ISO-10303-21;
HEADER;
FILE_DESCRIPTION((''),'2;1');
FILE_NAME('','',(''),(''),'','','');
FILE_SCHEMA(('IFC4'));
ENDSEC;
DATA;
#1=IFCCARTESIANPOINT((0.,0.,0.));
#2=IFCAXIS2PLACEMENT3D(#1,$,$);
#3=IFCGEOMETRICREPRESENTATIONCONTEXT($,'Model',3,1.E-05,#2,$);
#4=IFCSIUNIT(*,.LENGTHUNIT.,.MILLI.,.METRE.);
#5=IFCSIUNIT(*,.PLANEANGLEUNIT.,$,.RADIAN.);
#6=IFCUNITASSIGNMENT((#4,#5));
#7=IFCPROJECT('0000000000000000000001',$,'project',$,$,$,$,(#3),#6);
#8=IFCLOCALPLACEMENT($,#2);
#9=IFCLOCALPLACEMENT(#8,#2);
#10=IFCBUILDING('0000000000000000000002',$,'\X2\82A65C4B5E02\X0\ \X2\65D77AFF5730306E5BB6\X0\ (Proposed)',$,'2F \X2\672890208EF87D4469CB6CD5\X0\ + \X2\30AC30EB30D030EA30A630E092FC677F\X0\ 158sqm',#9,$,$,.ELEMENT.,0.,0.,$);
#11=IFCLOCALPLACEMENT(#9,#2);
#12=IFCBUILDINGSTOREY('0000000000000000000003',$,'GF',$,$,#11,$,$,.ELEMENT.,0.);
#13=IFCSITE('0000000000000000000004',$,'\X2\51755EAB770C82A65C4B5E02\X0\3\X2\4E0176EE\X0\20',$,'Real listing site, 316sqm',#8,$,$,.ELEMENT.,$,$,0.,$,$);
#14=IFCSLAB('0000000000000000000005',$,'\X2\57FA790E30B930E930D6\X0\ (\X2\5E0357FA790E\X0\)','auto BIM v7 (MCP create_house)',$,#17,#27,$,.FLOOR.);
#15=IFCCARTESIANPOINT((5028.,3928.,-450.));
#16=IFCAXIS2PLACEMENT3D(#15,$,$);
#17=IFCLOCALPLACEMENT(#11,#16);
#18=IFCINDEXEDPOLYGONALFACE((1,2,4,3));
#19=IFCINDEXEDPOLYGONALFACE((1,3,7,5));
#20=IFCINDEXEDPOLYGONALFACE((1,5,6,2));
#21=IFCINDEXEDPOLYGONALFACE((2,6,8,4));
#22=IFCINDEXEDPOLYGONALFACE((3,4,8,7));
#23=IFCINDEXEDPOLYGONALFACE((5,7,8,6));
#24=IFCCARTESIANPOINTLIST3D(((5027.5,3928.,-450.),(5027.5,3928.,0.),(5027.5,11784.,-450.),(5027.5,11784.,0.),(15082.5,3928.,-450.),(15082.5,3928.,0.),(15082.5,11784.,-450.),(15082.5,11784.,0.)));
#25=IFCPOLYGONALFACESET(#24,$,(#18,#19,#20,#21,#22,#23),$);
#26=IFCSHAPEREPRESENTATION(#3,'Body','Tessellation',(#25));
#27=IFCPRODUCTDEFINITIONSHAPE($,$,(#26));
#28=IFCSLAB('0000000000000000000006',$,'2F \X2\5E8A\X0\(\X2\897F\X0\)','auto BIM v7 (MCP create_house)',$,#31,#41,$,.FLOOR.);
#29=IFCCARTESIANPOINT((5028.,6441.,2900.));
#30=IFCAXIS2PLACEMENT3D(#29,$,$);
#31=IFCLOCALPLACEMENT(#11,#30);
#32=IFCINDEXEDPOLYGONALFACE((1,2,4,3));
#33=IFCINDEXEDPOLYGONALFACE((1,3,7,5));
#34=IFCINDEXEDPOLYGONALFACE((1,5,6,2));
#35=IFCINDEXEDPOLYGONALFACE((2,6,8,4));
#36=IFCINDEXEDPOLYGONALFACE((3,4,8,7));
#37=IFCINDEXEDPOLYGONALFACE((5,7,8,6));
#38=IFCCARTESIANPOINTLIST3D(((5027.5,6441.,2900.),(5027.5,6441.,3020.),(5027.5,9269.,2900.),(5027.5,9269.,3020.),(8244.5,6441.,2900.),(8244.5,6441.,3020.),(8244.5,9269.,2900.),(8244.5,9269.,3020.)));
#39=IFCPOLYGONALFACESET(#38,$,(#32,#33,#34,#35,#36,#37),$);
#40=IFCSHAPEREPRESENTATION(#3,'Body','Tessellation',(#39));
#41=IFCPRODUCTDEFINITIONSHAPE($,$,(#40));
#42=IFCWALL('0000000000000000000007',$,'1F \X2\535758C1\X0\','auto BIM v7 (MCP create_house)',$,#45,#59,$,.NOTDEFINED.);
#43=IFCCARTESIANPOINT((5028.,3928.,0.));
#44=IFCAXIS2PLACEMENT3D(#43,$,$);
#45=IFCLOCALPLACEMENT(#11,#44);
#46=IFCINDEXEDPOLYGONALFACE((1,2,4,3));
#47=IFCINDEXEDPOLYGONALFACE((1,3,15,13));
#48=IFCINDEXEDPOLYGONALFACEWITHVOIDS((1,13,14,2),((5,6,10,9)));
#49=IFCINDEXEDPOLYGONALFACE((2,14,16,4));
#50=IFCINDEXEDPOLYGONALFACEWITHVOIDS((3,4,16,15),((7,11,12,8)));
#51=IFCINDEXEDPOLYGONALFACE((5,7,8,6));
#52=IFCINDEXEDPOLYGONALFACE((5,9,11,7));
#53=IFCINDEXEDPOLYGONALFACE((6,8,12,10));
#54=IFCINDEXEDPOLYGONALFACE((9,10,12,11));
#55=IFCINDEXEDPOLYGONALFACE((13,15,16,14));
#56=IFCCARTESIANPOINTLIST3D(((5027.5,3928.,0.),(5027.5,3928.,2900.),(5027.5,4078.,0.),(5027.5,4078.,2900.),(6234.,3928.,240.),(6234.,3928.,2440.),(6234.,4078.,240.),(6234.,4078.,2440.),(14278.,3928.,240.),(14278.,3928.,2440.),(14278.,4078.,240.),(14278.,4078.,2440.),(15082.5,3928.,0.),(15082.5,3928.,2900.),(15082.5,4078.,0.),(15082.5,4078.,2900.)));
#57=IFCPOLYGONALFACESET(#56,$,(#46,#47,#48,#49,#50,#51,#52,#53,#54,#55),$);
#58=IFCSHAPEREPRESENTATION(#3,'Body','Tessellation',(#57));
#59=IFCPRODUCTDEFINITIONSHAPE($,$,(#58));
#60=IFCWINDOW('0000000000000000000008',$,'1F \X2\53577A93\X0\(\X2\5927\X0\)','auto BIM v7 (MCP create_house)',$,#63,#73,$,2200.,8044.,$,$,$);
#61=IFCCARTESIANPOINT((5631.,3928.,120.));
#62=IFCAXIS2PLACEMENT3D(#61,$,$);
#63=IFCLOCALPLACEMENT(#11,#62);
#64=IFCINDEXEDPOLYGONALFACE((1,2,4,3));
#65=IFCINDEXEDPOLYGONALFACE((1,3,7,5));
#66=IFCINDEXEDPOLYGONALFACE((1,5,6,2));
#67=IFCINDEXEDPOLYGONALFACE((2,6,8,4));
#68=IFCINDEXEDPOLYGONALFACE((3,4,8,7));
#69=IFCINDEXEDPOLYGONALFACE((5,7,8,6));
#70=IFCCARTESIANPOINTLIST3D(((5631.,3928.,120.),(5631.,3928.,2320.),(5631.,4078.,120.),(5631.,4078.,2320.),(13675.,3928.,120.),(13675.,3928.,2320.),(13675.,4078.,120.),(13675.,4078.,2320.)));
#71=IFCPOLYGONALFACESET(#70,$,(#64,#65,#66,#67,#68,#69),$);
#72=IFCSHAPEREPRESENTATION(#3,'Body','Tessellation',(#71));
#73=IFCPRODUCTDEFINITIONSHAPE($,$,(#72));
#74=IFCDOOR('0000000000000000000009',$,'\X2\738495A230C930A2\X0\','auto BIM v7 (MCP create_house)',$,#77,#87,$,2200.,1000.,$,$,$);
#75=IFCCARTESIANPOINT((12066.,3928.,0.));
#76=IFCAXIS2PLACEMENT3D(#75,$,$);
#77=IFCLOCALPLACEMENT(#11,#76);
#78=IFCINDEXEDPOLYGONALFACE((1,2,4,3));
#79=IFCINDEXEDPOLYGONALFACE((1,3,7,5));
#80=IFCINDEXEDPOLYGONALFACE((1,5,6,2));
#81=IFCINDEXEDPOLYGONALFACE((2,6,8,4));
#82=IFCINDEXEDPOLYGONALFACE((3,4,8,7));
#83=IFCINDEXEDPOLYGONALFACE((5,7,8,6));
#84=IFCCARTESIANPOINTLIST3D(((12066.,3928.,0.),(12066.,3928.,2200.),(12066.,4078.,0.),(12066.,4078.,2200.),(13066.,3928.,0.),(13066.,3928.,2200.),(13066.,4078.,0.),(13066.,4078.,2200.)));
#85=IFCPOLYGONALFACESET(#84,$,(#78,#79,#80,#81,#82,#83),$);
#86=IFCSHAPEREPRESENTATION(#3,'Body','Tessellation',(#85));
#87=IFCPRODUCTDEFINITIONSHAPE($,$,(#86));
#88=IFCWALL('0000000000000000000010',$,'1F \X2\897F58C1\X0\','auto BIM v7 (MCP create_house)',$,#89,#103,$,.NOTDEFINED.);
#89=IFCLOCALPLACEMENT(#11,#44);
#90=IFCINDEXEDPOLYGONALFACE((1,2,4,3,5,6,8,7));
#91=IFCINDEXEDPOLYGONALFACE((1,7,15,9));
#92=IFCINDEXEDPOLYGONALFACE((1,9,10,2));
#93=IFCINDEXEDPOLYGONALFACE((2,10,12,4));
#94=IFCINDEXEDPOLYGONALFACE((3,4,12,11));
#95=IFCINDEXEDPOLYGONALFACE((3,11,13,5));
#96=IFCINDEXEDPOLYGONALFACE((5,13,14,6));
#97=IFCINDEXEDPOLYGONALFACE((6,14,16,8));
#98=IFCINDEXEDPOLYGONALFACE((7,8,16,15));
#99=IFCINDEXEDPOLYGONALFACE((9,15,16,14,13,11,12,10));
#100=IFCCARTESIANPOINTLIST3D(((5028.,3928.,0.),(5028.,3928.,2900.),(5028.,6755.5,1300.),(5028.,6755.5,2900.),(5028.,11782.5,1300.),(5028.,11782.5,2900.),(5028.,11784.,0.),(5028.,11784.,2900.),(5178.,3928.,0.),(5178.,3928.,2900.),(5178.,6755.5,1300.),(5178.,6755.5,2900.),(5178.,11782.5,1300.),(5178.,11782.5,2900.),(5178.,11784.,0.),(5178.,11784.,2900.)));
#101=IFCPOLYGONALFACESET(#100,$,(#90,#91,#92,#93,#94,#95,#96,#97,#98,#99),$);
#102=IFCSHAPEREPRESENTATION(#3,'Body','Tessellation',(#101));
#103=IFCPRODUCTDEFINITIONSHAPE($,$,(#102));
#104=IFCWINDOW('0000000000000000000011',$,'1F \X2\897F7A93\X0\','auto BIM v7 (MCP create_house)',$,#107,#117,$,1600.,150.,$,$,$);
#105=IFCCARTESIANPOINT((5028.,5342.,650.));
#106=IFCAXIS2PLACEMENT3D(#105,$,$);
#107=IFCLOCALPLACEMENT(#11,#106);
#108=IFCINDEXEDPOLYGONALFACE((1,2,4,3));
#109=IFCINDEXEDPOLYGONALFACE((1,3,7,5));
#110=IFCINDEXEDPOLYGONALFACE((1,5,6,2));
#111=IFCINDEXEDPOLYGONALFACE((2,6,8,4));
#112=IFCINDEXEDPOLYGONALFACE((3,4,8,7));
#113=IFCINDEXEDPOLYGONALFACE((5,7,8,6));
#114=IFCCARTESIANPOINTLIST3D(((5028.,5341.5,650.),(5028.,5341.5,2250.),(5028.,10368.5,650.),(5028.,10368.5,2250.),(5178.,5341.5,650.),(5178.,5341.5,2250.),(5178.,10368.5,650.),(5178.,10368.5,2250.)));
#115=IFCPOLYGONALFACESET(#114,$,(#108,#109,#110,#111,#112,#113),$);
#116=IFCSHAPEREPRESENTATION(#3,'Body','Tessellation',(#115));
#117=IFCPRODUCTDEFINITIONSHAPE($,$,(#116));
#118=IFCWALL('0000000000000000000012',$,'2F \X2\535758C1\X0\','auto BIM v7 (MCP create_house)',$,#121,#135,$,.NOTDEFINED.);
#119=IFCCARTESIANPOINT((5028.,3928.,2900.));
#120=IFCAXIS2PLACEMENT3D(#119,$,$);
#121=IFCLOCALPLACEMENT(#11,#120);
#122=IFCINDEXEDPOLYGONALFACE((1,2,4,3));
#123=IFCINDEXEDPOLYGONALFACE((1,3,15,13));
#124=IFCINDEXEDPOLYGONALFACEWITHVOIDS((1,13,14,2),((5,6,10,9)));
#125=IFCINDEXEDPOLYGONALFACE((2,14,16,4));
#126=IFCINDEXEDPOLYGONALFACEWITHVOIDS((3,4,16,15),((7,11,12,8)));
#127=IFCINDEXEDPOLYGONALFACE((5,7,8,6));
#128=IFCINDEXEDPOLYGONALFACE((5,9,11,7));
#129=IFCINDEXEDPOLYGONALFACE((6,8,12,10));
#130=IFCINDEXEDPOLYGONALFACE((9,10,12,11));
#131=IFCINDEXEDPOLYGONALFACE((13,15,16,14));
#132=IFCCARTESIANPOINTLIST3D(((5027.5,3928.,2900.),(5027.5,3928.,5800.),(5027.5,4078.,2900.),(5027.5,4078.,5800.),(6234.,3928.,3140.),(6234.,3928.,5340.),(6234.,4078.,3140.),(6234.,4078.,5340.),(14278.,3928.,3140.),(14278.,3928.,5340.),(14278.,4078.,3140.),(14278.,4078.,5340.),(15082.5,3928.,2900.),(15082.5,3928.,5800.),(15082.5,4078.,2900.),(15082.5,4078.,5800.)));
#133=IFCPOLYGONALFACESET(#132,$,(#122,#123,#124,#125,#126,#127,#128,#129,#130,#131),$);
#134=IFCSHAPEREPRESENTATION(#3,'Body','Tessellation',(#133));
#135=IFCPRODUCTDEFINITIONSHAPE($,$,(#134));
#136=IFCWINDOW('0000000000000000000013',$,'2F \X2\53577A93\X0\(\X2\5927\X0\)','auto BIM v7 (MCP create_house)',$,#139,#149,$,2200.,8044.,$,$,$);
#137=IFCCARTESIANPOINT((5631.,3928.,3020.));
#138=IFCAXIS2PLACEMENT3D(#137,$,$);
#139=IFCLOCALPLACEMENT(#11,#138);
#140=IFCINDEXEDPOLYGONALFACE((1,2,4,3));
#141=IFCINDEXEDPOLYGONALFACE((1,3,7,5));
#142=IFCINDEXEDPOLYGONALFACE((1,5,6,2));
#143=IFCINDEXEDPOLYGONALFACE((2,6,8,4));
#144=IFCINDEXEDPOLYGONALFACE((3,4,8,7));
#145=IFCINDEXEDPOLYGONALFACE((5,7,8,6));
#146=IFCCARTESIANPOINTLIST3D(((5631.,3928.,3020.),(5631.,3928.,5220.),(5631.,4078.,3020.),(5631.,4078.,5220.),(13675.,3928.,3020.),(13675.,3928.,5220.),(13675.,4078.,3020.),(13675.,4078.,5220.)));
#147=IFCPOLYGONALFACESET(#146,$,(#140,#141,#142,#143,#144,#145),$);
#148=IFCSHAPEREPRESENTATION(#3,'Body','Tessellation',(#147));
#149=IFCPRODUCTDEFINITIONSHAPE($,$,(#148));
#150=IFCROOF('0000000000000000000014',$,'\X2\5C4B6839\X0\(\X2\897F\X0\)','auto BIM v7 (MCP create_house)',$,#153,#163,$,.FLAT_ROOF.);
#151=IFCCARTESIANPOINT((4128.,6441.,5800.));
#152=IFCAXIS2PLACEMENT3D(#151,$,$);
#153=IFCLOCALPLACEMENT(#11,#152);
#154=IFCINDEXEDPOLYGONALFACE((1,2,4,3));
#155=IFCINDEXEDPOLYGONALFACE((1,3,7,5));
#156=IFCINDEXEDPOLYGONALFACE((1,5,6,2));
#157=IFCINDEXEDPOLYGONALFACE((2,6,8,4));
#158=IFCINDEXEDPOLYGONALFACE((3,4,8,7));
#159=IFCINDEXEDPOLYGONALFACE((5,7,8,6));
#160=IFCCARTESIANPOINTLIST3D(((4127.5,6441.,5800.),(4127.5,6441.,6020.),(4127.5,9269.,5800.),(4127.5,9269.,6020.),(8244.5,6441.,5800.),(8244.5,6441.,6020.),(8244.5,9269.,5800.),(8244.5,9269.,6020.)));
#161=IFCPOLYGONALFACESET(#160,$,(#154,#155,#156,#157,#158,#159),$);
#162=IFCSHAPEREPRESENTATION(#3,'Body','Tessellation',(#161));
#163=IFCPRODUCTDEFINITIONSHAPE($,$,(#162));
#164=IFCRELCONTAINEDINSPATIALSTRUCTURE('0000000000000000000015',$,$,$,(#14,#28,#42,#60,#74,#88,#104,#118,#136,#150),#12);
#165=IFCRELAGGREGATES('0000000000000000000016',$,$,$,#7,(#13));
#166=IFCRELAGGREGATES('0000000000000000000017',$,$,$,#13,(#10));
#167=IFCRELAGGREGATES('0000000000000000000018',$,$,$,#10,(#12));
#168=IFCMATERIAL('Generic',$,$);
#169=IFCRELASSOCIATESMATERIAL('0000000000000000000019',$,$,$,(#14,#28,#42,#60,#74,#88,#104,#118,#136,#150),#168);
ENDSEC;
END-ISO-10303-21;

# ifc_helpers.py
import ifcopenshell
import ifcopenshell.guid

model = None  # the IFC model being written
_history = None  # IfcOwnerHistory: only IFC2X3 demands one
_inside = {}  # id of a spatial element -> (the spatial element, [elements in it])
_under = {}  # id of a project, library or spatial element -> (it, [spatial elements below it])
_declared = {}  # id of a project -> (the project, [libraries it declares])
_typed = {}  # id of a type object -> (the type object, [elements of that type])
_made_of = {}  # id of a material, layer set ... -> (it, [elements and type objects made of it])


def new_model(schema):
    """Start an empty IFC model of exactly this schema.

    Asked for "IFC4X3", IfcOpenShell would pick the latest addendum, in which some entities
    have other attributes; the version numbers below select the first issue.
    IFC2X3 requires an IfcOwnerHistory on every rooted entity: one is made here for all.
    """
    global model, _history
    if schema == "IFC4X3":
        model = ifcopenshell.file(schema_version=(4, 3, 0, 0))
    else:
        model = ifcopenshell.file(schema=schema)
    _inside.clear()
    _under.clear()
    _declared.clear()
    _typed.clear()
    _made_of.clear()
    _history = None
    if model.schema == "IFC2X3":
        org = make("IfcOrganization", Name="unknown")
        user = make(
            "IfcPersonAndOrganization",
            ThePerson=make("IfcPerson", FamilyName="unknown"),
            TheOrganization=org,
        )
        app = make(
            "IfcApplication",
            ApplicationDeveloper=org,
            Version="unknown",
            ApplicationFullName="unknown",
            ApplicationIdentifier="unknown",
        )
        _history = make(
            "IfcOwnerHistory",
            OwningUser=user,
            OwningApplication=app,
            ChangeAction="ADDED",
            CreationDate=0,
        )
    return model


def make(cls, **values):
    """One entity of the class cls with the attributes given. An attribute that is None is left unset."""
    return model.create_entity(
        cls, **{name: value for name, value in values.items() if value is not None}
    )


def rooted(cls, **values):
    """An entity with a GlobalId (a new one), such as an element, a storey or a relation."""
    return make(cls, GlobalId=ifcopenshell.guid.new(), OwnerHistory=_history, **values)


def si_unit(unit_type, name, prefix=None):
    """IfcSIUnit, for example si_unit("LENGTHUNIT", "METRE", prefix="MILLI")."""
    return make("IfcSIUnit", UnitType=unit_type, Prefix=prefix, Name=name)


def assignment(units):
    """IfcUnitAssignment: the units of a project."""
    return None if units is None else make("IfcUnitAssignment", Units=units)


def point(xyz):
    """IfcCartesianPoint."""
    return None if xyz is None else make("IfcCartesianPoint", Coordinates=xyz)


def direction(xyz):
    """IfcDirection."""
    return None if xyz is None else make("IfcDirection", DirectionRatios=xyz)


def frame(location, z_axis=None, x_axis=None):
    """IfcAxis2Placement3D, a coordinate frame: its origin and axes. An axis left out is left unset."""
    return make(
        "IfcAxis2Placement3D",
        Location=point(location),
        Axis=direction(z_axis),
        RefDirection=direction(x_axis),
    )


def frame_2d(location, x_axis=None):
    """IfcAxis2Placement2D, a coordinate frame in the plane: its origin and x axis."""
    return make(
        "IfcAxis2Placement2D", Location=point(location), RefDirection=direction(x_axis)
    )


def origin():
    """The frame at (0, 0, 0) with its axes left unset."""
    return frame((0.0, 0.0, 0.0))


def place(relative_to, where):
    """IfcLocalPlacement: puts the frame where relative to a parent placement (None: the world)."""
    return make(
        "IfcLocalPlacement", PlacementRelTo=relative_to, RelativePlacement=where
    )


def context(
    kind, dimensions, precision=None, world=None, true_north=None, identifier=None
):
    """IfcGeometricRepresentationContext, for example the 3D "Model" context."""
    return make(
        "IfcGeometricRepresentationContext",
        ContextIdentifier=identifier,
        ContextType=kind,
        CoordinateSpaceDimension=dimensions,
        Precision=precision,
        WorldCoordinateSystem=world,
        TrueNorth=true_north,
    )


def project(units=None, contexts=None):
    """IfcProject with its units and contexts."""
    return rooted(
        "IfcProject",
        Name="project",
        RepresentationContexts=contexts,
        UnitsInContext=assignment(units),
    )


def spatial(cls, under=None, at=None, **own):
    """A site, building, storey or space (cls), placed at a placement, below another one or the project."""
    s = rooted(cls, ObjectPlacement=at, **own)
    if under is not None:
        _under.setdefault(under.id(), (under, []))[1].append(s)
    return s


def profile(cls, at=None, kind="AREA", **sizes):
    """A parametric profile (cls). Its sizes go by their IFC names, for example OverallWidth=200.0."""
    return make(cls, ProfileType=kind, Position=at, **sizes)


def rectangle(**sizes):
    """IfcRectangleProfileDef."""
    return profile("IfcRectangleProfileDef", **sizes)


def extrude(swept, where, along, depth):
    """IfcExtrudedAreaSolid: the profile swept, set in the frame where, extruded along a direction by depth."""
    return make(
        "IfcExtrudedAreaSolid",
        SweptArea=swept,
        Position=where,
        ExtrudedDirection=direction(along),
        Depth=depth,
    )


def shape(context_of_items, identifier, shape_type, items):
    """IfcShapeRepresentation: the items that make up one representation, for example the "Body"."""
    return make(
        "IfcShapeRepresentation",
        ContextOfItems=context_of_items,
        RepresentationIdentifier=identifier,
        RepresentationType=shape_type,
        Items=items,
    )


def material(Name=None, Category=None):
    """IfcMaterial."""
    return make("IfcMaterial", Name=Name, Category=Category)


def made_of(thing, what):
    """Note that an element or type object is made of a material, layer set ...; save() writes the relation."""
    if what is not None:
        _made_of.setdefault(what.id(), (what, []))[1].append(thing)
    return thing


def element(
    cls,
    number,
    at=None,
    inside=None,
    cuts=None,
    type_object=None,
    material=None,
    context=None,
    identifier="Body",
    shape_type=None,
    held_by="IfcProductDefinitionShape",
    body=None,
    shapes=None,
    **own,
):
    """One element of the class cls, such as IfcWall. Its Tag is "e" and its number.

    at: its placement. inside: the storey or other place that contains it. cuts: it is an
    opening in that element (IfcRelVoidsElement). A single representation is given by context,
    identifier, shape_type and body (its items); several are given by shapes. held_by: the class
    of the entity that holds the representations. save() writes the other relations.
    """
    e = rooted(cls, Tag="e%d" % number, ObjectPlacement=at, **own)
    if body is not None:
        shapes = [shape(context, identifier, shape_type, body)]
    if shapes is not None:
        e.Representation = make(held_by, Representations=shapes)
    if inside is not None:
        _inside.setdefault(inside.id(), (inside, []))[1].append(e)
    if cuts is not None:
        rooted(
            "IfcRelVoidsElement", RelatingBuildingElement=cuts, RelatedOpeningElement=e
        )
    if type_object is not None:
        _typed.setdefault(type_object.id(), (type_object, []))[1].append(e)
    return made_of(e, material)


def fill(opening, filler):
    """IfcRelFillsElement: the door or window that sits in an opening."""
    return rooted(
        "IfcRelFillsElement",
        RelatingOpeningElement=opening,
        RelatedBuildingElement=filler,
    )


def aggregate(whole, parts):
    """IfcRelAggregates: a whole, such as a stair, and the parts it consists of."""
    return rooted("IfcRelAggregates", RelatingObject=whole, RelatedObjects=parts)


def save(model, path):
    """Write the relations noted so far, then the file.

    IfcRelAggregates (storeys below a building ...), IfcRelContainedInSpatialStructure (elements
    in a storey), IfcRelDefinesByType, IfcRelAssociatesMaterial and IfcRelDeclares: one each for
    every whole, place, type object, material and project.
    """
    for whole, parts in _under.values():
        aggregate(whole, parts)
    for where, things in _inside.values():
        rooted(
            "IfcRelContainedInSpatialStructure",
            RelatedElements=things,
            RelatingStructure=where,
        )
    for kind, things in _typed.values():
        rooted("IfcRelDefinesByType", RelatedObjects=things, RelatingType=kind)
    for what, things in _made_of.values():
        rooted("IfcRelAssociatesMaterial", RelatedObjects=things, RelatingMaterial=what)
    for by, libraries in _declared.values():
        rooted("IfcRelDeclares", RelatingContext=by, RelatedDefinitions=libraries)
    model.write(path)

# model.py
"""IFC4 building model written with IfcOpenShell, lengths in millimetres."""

from ifc_helpers import new_model, si_unit, frame, frame_2d, origin, place, context, project, spatial, rectangle, extrude, material, element, fill, save


model = new_model("IFC4")

# Units and contexts
model_context = context("Model", 3, precision=1e-05, world=origin())
ifc_project = project(units=[si_unit("LENGTHUNIT", "METRE", prefix="MILLI"), si_unit("PLANEANGLEUNIT", "RADIAN")], contexts=[model_context])

# Site, building, storey
site_placement = place(None, origin())
site = spatial("IfcSite", under=ifc_project, at=site_placement, Name="兵庫県芦屋市3丁目20", ObjectType="Real listing site, 316sqm", CompositionType="ELEMENT", RefElevation=0.0)
building_placement = place(site_placement, origin())
building = spatial("IfcBuilding", under=site, at=building_placement, Name="芦屋市 旗竿地の家 (Proposed)", ObjectType="2F 木造軸組構法 + ガルバリウム鋼板 158sqm", CompositionType="ELEMENT", ElevationOfRefHeight=0.0, ElevationOfTerrain=0.0)
storey_placement = place(building_placement, origin())
storey = spatial("IfcBuildingStorey", under=building, at=storey_placement, Name="GF", CompositionType="ELEMENT", Elevation=0.0)

# Slabs
ifc_material = material(Name="Generic")
slab_1_placement = place(storey_placement, frame((5028.0, 3928.0, -450.0)))
element("IfcSlab", 1, at=slab_1_placement, inside=storey, material=ifc_material, Name="基礎スラブ (布基礎)", Description="auto BIM v7 (MCP create_house)", PredefinedType="FLOOR", context=model_context, shape_type="SweptSolid", body=[
    extrude(rectangle(XDim=10055.0, YDim=7856.0, at=frame_2d((5027.0, 3928.0))), frame((5028.0, 3928.0, -450.0)), (0.0, 0.0, 1.0), 450.0),
])
slab_2_placement = place(storey_placement, frame((5028.0, 6441.0, 2900.0)))
element("IfcSlab", 2, at=slab_2_placement, inside=storey, material=ifc_material, Name="2F 床(西)", Description="auto BIM v7 (MCP create_house)", PredefinedType="FLOOR", context=model_context, shape_type="SweptSolid", body=[
    extrude(rectangle(XDim=3217.0, YDim=2828.0, at=frame_2d((1608.0, 1414.0))), frame((5028.0, 6441.0, 2900.0)), (0.0, 0.0, 1.0), 120.0),
])

# Wall, openings, window, door
wall_1_placement = place(storey_placement, frame((5028.0, 3928.0, 0.0)))
wall_1 = element("IfcWall", 3, at=wall_1_placement, inside=storey, material=ifc_material, Name="1F 南壁", Description="auto BIM v7 (MCP create_house)", PredefinedType="NOTDEFINED", context=model_context, shape_type="SweptSolid", body=[
    extrude(rectangle(XDim=10055.0, YDim=150.0, at=frame_2d((5027.0, 75.0))), frame((5028.0, 3928.0, 0.0)), (0.0, 0.0, 1.0), 2900.0),
])
opening_1_placement = place(storey_placement, frame((5631.0, 3928.0, 120.0)))
opening_1 = element("IfcOpeningElement", 4, at=opening_1_placement, cuts=wall_1, PredefinedType="NOTDEFINED", context=model_context, shape_type="SweptSolid", body=[
    extrude(rectangle(XDim=8044.0, YDim=150.0, at=frame_2d((4022.0, 75.0))), frame((5631.0, 3928.0, 120.0)), (0.0, 0.0, 1.0), 2200.0),
])
opening_2_placement = place(storey_placement, frame((12066.0, 3928.0, 0.0)))
opening_2 = element("IfcOpeningElement", 5, at=opening_2_placement, cuts=wall_1, PredefinedType="NOTDEFINED", context=model_context, shape_type="SweptSolid", body=[
    extrude(rectangle(XDim=1000.0, YDim=150.0, at=frame_2d((500.0, 75.0))), frame((12066.0, 3928.0, 0.0)), (0.0, 0.0, 1.0), 2200.0),
])
window_1_placement = place(storey_placement, frame((5631.0, 3928.0, 120.0)))
window_1 = element("IfcWindow", 6, at=window_1_placement, inside=storey, material=ifc_material, Name="1F 南窓(大)", Description="auto BIM v7 (MCP create_house)", OverallHeight=2200.0, OverallWidth=8044.0, context=model_context, shape_type="SweptSolid", body=[
    extrude(rectangle(XDim=8044.0, YDim=150.0, at=frame_2d((4022.0, 75.0))), frame((5631.0, 3928.0, 120.0)), (0.0, 0.0, 1.0), 2200.0),
])
fill(opening_1, window_1)
door_placement = place(storey_placement, frame((12066.0, 3928.0, 0.0)))
door = element("IfcDoor", 7, at=door_placement, inside=storey, material=ifc_material, Name="玄関ドア", Description="auto BIM v7 (MCP create_house)", OverallHeight=2200.0, OverallWidth=1000.0, context=model_context, shape_type="SweptSolid", body=[
    extrude(rectangle(XDim=1000.0, YDim=150.0, at=frame_2d((500.0, 75.0))), frame((12066.0, 3928.0, 0.0)), (0.0, 0.0, 1.0), 2200.0),
])
fill(opening_2, door)

# Walls, openings, windows
wall_2_placement = place(storey_placement, frame((5028.0, 3928.0, 0.0)))
wall_2 = element("IfcWall", 8, at=wall_2_placement, inside=storey, material=ifc_material, Name="1F 西壁", Description="auto BIM v7 (MCP create_house)", PredefinedType="NOTDEFINED", context=model_context, shape_type="SweptSolid", body=[
    extrude(rectangle(XDim=150.0, YDim=7856.0, at=frame_2d((75.0, 3928.0))), frame((5028.0, 3928.0, 0.0)), (0.0, 0.0, 1.0), 2900.0),
])
opening_3_placement = place(storey_placement, frame((5028.0, 5342.0, 650.0)))
opening_3 = element("IfcOpeningElement", 9, at=opening_3_placement, cuts=wall_2, PredefinedType="NOTDEFINED", context=model_context, shape_type="SweptSolid", body=[
    extrude(rectangle(XDim=150.0, YDim=5027.0, at=frame_2d((75.0, 2513.0))), frame((5028.0, 5342.0, 650.0)), (0.0, 0.0, 1.0), 1600.0),
])
window_2_placement = place(storey_placement, frame((5028.0, 5342.0, 650.0)))
window_2 = element("IfcWindow", 10, at=window_2_placement, inside=storey, material=ifc_material, Name="1F 西窓", Description="auto BIM v7 (MCP create_house)", OverallHeight=1600.0, OverallWidth=150.0, context=model_context, shape_type="SweptSolid", body=[
    extrude(rectangle(XDim=150.0, YDim=5027.0, at=frame_2d((75.0, 2513.0))), frame((5028.0, 5342.0, 650.0)), (0.0, 0.0, 1.0), 1600.0),
])
fill(opening_3, window_2)
wall_3_placement = place(storey_placement, frame((5028.0, 3928.0, 2900.0)))
wall_3 = element("IfcWall", 11, at=wall_3_placement, inside=storey, material=ifc_material, Name="2F 南壁", Description="auto BIM v7 (MCP create_house)", PredefinedType="NOTDEFINED", context=model_context, shape_type="SweptSolid", body=[
    extrude(rectangle(XDim=10055.0, YDim=150.0, at=frame_2d((5027.0, 75.0))), frame((5028.0, 3928.0, 2900.0)), (0.0, 0.0, 1.0), 2900.0),
])
opening_4_placement = place(storey_placement, frame((5631.0, 3928.0, 3020.0)))
opening_4 = element("IfcOpeningElement", 12, at=opening_4_placement, cuts=wall_3, PredefinedType="NOTDEFINED", context=model_context, shape_type="SweptSolid", body=[
    extrude(rectangle(XDim=8044.0, YDim=150.0, at=frame_2d((4022.0, 75.0))), frame((5631.0, 3928.0, 3020.0)), (0.0, 0.0, 1.0), 2200.0),
])
window_3_placement = place(storey_placement, frame((5631.0, 3928.0, 3020.0)))
window_3 = element("IfcWindow", 13, at=window_3_placement, inside=storey, material=ifc_material, Name="2F 南窓(大)", Description="auto BIM v7 (MCP create_house)", OverallHeight=2200.0, OverallWidth=8044.0, context=model_context, shape_type="SweptSolid", body=[
    extrude(rectangle(XDim=8044.0, YDim=150.0, at=frame_2d((4022.0, 75.0))), frame((5631.0, 3928.0, 3020.0)), (0.0, 0.0, 1.0), 2200.0),
])
fill(opening_4, window_3)

# Roof
roof_1_placement = place(storey_placement, frame((4128.0, 6441.0, 5800.0)))
element("IfcRoof", 14, at=roof_1_placement, inside=storey, material=ifc_material, Name="屋根(西)", Description="auto BIM v7 (MCP create_house)", PredefinedType="FLAT_ROOF", context=model_context, shape_type="SweptSolid", body=[
    extrude(rectangle(XDim=4117.0, YDim=2828.0, at=frame_2d((2058.0, 1414.0))), frame((4128.0, 6441.0, 5800.0)), (0.0, 0.0, 1.0), 220.0),
])

save(model, "model.ifc")
